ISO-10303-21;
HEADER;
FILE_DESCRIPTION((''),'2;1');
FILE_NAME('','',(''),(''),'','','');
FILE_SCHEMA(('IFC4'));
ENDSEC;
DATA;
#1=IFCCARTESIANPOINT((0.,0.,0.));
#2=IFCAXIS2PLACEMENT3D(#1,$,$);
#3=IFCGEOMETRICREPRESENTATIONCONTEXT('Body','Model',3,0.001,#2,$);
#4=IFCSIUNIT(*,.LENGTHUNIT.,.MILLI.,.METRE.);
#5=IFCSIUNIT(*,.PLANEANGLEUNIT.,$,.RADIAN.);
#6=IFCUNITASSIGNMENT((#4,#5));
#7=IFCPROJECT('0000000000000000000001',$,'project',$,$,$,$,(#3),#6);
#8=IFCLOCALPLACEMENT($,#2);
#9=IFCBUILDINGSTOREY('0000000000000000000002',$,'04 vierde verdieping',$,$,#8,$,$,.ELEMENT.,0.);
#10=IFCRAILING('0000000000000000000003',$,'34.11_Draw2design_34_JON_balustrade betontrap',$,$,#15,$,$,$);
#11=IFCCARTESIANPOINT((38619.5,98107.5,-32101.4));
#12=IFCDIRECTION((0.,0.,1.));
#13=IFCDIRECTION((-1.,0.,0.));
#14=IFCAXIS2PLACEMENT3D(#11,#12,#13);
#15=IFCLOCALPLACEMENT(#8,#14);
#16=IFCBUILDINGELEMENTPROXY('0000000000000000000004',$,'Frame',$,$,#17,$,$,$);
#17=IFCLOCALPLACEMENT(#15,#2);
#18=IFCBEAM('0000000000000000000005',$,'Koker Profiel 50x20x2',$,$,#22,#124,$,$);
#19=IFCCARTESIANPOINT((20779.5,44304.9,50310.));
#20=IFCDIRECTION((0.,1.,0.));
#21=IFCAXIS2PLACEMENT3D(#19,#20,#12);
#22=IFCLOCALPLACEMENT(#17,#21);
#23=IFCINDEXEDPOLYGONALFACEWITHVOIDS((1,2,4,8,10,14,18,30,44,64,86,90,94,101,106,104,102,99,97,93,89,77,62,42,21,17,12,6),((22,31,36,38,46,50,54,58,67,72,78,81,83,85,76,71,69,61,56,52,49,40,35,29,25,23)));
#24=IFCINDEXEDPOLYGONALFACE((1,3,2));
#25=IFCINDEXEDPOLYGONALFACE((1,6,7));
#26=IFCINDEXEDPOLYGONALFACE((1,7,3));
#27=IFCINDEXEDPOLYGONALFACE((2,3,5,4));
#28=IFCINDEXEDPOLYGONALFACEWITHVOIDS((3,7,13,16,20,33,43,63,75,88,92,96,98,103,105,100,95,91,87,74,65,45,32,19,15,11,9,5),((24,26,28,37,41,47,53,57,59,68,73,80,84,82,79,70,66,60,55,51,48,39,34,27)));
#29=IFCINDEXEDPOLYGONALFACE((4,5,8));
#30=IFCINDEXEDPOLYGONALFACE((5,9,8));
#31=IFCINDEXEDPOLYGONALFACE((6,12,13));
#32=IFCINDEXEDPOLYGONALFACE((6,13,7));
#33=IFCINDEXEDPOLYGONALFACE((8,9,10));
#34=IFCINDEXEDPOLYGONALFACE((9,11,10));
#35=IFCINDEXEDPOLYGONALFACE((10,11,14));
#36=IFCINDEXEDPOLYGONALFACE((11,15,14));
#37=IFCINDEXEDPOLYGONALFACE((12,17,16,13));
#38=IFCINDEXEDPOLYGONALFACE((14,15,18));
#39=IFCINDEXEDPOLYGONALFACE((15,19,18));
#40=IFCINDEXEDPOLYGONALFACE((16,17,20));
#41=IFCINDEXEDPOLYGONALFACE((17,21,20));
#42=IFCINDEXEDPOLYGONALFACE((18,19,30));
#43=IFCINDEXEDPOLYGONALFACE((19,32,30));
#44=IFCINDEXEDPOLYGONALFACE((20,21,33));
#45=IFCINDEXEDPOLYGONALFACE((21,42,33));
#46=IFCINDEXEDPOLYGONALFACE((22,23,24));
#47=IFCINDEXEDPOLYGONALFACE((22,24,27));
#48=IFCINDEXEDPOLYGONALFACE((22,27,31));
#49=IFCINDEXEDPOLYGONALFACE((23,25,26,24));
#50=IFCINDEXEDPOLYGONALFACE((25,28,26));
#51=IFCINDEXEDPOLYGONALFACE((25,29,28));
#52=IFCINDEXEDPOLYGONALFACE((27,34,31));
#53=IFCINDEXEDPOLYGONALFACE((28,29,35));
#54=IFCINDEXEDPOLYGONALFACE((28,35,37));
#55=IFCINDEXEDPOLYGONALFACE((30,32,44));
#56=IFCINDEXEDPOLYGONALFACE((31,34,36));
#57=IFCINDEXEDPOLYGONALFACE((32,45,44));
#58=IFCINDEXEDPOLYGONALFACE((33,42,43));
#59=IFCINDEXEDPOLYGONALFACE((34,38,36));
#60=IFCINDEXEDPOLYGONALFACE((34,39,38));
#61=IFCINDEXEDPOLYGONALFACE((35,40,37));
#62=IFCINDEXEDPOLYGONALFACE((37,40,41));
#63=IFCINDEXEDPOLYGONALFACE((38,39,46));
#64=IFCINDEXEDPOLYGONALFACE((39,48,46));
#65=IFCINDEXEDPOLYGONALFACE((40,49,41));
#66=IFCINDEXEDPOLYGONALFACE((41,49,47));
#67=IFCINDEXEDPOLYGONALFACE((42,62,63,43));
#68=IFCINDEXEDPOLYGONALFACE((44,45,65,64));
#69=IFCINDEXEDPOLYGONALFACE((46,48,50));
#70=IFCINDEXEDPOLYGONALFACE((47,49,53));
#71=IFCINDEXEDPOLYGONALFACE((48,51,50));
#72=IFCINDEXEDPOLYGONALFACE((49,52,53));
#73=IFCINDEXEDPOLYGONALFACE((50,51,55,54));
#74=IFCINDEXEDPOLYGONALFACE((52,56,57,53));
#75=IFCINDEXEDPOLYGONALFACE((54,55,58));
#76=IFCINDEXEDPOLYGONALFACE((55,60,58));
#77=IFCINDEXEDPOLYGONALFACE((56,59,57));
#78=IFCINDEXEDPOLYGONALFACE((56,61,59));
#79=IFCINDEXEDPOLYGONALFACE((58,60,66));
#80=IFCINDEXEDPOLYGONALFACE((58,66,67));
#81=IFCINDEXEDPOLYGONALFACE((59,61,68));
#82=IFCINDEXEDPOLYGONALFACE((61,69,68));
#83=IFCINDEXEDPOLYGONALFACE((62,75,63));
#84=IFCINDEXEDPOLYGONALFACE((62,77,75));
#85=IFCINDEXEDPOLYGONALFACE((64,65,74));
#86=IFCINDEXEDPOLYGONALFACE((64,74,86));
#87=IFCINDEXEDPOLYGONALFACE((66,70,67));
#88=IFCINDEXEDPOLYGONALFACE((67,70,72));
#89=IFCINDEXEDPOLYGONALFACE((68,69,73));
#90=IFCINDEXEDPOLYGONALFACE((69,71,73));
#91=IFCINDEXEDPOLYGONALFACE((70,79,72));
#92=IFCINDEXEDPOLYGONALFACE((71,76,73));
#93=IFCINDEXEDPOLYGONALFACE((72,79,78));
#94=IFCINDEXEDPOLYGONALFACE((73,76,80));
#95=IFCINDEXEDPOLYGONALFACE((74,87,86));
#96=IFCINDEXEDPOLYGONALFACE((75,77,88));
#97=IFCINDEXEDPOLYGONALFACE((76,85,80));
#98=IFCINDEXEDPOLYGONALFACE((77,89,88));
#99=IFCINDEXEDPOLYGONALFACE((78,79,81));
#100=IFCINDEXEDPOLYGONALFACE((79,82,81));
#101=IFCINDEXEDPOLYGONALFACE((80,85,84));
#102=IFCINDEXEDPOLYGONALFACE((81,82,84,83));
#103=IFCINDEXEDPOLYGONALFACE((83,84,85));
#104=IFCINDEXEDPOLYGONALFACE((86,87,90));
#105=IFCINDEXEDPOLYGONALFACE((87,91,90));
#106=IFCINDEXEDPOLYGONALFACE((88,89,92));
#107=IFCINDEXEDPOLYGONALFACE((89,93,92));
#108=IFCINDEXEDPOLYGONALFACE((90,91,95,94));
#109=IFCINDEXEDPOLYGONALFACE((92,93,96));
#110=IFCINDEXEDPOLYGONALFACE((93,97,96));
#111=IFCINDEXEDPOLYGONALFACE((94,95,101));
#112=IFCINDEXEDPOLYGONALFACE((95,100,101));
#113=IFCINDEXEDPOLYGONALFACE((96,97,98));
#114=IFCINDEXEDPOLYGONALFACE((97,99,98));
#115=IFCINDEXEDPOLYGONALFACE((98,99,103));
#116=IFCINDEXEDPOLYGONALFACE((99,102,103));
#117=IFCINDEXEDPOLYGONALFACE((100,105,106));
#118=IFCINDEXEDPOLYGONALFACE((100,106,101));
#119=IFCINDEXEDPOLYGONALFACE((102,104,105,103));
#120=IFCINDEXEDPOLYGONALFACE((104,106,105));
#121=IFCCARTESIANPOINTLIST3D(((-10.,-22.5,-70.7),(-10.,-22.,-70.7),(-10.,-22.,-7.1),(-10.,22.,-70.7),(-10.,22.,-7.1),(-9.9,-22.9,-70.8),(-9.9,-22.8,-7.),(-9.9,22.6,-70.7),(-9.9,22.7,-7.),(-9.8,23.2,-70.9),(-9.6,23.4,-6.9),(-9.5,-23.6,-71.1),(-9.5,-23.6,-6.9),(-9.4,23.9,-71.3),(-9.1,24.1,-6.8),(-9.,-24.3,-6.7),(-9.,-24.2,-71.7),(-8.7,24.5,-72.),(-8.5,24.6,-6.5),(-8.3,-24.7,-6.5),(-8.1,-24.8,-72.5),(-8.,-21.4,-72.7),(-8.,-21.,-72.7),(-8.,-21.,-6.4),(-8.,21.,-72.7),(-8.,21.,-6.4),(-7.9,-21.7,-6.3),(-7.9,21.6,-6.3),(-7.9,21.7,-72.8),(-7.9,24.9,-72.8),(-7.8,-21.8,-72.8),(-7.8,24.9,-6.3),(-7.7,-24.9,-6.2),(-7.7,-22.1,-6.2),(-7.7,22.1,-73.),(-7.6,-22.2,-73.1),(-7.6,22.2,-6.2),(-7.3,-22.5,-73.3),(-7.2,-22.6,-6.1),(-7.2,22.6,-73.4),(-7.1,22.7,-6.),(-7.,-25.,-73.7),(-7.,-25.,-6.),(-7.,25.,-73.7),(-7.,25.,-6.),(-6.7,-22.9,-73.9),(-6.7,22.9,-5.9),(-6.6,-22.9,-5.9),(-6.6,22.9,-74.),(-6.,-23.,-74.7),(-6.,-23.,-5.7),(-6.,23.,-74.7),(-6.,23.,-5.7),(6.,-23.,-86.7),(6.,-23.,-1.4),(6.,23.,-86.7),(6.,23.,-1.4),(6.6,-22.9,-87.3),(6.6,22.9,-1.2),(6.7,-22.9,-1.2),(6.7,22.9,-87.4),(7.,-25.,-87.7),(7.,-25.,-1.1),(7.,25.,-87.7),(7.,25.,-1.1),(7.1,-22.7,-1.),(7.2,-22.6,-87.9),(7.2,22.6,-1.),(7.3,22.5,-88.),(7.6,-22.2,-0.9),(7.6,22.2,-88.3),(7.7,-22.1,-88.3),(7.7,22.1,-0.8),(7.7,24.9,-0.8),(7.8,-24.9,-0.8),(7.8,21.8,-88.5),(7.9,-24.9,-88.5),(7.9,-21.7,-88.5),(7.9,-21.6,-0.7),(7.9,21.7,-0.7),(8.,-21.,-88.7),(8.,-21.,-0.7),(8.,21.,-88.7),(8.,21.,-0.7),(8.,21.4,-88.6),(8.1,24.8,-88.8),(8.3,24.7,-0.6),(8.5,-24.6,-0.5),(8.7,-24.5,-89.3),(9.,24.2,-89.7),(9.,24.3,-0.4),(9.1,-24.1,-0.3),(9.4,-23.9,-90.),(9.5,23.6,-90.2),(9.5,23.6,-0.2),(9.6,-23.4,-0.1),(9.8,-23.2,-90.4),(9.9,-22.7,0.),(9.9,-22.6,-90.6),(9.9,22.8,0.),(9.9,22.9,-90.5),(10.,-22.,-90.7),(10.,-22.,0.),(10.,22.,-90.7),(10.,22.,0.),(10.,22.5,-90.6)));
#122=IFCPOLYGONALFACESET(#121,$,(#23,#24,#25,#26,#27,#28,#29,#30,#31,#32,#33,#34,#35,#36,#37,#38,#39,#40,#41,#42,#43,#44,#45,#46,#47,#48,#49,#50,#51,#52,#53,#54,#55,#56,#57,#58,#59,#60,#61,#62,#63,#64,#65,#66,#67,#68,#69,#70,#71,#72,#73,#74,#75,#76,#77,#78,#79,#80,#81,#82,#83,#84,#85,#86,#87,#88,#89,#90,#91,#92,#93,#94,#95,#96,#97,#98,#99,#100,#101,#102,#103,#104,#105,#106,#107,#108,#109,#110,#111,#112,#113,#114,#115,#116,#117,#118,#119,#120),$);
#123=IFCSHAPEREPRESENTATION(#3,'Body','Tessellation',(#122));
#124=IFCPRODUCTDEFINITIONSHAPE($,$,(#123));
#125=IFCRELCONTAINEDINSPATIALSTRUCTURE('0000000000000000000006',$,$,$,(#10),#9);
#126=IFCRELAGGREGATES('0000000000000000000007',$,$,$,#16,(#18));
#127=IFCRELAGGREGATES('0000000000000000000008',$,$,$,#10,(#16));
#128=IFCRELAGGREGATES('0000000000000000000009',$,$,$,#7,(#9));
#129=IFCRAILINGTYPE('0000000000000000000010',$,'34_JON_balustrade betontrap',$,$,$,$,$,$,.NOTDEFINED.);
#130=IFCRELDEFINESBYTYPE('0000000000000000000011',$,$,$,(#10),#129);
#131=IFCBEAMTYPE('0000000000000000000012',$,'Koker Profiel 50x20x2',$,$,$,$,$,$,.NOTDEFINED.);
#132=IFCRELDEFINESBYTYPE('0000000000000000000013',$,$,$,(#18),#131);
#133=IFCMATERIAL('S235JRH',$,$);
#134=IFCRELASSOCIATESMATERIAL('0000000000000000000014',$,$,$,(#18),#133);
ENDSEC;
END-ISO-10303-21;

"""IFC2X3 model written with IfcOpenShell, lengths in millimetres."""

from ifc_helpers import new_model, si_unit, frame, origin, origin_2d, place, context, project, spatial, hollow_rectangle, extrude, clip, halfspace, source, transform, mapped, material, type_object, element, aggregate, save


model = new_model("IFC2X3")

# Units and contexts
model_context = context("Model", 3, precision=0.001, world=origin(), identifier="Body")
ifc_project = project(units=[si_unit("LENGTHUNIT", "METRE", prefix="MILLI"), si_unit("PLANEANGLEUNIT", "RADIAN")], contexts=[model_context])

# Storey
storey_placement = place(None, origin())
storey = spatial("IfcBuildingStorey", under=ifc_project, at=storey_placement, Name="04 vierde verdieping", CompositionType="ELEMENT", Elevation=0.0)

# Railing, building element proxy, beam
railing_type = type_object("IfcRailingType", Name="34_JON_balustrade betontrap")
railing_placement = place(storey_placement, frame((38619.5, 98107.5, -32101.4), z_axis=(0.0, 0.0, 1.0), x_axis=(-1.0, 0.0, 0.0)))
railing = element("IfcRailing", 1, at=railing_placement, inside=storey, type_object=railing_type, Name="34.11_Draw2design_34_JON_balustrade betontrap")
ifc_material_1 = material(Name="S235JRH")
proxy_1_placement = place(railing_placement, origin())
proxy_1 = element("IfcBuildingElementProxy", 2, at=proxy_1_placement, Name="Frame")
beam_type_1 = type_object("IfcBeamType", Name="Koker Profiel 50x20x2")
shared_shape_1 = source(origin(), model_context, "Body", "Clipping", [
    clip(clip(extrude(hollow_rectangle(XDim=20.0, YDim=50.0, WallThickness=2.0, InnerFilletRadius=2.0, OuterFilletRadius=3.0, at=origin_2d()), origin(), (0.0, 0.0, -1.0), 90.7), halfspace(frame((-10.0, 25.0, -7.1), z_axis=(-0.33335, 0.0, 0.942803), x_axis=(0.0, 1.0, 0.0)), False)), halfspace(frame((-10.0, -25.0, -70.7), z_axis=(-0.707107, 0.0, -0.707107), x_axis=(0.0, -1.0, 0.0)), False)),
])
beam_1_placement = place(proxy_1_placement, frame((20779.5, 44304.9, 50310.0), z_axis=(0.0, 1.0, 0.0), x_axis=(0.0, 0.0, 1.0)))
beam_1 = element("IfcBeam", 3, at=beam_1_placement, type_object=beam_type_1, material=ifc_material_1, Name="Koker Profiel 50x20x2", context=model_context, shape_type="MappedRepresentation", body=[
    mapped(shared_shape_1, transform((0.0, 0.0, 0.0), scale=1.0)),
])
aggregate(proxy_1, [beam_1])
aggregate(railing, [proxy_1])

save(model, "model.ifc")
